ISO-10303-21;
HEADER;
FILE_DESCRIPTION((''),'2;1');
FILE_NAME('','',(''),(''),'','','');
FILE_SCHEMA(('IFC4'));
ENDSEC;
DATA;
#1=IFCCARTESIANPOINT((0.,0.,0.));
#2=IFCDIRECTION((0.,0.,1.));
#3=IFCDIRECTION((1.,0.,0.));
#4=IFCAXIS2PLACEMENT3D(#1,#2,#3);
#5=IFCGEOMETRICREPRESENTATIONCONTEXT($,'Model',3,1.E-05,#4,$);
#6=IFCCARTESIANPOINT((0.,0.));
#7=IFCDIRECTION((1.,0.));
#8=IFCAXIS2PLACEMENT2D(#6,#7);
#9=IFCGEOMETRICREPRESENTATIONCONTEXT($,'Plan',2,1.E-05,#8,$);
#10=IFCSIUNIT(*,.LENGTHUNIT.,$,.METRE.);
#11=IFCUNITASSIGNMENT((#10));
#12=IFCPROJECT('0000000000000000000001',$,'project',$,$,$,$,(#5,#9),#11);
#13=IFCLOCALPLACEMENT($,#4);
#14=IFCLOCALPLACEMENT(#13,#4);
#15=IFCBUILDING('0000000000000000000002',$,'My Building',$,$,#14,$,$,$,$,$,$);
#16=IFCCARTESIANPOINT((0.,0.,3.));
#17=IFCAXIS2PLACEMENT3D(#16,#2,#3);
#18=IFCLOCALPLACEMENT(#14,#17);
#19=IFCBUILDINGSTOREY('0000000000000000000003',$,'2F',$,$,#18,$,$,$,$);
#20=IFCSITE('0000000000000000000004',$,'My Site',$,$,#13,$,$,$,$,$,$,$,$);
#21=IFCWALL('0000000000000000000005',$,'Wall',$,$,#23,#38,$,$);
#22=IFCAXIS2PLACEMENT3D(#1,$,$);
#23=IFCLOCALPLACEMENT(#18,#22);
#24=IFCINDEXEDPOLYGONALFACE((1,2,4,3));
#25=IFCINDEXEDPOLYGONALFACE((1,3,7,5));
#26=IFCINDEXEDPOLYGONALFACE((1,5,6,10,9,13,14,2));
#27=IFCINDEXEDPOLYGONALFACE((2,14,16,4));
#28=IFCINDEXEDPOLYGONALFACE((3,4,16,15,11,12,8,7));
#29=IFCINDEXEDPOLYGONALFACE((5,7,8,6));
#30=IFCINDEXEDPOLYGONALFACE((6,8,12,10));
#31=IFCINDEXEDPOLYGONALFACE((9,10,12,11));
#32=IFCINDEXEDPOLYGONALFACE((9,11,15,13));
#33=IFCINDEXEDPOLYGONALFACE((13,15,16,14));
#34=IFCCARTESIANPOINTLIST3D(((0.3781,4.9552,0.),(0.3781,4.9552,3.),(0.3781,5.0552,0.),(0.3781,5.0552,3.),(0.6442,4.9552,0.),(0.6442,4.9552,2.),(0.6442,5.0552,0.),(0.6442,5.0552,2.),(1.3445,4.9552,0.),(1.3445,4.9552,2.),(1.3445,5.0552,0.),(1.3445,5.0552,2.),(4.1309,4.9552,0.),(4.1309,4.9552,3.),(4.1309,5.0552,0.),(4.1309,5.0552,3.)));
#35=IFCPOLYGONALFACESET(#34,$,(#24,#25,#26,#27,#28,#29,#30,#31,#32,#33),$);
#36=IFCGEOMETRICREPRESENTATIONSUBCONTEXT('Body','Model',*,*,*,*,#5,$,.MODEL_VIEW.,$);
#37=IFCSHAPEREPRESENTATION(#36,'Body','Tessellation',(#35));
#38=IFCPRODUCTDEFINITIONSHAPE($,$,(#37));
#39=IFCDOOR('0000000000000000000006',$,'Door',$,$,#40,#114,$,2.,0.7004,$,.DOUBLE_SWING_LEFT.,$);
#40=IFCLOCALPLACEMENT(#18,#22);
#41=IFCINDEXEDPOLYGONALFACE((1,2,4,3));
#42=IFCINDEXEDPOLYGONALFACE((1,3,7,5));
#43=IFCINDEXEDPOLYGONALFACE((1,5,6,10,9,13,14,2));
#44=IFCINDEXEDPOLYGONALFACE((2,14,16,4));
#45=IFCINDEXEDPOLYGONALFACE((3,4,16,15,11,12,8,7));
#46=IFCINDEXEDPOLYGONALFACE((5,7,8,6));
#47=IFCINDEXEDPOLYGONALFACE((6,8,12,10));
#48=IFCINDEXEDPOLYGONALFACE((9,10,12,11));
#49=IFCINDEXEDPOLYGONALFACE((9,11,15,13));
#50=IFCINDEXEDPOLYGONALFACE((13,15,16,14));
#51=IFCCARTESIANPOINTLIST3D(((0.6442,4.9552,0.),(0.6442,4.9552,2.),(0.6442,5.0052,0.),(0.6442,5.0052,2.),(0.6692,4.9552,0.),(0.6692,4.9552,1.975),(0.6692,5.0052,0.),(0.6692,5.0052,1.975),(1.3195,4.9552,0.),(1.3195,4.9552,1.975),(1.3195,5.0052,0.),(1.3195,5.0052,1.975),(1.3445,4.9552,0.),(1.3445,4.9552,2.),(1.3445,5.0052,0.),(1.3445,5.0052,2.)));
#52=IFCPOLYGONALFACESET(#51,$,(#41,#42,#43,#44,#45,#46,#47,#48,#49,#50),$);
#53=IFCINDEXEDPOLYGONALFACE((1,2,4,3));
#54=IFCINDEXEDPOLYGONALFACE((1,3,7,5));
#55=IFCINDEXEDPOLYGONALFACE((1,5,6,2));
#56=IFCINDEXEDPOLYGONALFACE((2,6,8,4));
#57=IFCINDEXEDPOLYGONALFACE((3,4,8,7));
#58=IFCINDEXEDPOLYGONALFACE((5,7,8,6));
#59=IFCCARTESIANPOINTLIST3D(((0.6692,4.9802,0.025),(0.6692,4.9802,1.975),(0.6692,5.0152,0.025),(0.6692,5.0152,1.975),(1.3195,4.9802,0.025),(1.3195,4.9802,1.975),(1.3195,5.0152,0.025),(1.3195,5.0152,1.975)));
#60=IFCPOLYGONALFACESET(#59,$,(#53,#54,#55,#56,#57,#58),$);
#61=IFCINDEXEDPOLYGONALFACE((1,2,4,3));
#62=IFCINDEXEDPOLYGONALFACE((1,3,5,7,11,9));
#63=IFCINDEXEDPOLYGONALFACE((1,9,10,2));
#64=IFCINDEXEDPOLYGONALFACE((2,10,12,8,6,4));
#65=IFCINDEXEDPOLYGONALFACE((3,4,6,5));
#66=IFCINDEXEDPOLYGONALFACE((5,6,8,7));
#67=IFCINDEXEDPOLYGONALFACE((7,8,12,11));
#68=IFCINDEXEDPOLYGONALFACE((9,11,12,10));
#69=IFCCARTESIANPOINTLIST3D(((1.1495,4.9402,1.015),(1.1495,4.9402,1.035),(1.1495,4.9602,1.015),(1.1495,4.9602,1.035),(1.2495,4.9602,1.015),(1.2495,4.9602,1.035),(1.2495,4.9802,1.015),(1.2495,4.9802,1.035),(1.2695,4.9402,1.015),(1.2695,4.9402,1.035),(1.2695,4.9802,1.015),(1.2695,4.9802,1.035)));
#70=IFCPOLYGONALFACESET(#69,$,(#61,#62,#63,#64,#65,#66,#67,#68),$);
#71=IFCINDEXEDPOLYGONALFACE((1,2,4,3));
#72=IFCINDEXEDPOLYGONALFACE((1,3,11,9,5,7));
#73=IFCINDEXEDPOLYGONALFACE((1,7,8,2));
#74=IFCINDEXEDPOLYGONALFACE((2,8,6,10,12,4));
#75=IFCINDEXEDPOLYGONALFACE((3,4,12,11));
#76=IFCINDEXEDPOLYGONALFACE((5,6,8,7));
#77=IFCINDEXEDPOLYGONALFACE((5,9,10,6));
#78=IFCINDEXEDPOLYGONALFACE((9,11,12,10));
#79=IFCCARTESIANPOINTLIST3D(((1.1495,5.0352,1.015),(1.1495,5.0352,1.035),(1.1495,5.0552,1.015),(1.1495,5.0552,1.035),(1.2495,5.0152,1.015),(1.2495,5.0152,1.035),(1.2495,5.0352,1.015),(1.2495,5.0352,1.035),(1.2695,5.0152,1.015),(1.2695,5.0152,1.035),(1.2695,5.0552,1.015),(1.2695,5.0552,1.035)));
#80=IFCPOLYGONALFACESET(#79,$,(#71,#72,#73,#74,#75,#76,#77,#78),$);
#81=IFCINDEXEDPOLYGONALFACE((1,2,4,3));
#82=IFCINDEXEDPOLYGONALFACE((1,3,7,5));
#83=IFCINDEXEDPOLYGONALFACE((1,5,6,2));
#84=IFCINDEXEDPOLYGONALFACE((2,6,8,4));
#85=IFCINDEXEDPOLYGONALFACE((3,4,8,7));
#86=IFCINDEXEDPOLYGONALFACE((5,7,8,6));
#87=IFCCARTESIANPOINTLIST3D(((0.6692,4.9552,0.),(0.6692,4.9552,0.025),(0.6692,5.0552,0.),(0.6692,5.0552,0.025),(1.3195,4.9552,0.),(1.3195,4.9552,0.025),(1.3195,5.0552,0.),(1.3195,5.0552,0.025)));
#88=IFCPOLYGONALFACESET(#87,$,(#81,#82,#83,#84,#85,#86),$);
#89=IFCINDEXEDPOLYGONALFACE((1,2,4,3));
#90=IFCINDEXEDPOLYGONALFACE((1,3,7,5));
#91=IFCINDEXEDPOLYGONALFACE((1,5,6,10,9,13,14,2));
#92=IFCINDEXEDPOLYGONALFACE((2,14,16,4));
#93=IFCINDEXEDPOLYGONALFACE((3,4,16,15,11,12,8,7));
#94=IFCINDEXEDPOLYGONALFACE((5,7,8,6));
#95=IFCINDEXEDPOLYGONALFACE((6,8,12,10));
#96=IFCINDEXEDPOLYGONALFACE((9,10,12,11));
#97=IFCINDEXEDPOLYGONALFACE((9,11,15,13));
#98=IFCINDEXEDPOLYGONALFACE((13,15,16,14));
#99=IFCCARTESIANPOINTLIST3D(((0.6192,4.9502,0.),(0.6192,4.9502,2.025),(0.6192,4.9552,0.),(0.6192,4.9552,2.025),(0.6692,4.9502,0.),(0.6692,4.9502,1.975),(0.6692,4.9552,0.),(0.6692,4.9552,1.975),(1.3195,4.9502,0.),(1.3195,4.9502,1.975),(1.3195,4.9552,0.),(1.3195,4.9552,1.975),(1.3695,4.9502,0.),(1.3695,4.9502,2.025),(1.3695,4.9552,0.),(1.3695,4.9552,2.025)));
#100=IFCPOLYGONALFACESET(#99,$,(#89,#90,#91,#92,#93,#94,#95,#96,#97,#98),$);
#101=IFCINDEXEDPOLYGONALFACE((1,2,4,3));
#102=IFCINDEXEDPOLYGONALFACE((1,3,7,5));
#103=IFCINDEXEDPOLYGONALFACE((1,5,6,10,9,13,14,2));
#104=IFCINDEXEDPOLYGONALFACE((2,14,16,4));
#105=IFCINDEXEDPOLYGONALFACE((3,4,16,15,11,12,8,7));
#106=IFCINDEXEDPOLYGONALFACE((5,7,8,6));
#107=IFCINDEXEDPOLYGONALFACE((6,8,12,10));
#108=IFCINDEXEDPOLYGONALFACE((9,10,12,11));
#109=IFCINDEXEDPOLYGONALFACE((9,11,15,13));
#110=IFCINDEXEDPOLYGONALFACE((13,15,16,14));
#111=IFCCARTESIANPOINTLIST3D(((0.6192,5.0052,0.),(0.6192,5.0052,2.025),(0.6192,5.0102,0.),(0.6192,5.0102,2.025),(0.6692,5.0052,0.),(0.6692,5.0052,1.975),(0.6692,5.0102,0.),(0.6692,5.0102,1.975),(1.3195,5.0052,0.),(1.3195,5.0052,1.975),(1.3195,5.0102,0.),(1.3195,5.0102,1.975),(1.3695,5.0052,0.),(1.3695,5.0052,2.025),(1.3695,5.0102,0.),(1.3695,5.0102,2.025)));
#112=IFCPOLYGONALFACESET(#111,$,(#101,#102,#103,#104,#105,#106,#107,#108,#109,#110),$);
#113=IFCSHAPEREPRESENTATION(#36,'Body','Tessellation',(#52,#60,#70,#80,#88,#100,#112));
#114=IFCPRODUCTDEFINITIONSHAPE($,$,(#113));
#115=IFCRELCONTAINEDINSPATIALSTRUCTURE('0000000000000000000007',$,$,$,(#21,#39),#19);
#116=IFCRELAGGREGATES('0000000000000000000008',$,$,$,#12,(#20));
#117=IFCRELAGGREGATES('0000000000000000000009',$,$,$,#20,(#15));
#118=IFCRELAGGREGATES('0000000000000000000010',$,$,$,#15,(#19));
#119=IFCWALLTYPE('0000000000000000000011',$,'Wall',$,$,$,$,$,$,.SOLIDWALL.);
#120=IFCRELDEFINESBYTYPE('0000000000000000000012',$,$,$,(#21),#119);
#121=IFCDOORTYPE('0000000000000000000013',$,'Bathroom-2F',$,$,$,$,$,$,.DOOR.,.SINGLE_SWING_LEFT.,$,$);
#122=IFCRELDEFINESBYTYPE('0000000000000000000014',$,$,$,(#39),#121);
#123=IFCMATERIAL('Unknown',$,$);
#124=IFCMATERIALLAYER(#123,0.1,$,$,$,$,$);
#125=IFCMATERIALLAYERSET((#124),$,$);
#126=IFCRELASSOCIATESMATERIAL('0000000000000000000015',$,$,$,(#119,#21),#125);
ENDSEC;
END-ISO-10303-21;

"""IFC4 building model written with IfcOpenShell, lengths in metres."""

from ifc_helpers import new_model, entity, si_unit, frame, origin_with_axes, origin_2d_with_axis, place, context, subcontext, project, spatial, line, indexed_curve, outline, extrude, shape, source, transform, mapped, material, layer, layer_set, layer_usage, type_object, type_shapes, element, fill, save


model = new_model("IFC4")

# Units and contexts
model_context = context("Model", 3, precision=1e-05, world=origin_with_axes())
plan_context = context("Plan", 2, precision=1e-05, world=origin_2d_with_axis())
body_context_1 = subcontext(model_context, "Body", "Model", "MODEL_VIEW")
body_context_2 = subcontext(plan_context, "Body", "Plan", "PLAN_VIEW")
ifc_project = project(units=[si_unit("LENGTHUNIT", "METRE")], contexts=[model_context, plan_context])

# Site, building, storey
site_placement = place(None, origin_with_axes())
site = spatial("IfcSite", under=ifc_project, at=site_placement, Name="My Site")
building_placement = place(site_placement, origin_with_axes())
building = spatial("IfcBuilding", under=site, at=building_placement, Name="My Building")
storey_placement = place(building_placement, frame((0.0, 0.0, 3.0), z_axis=(0.0, 0.0, 1.0), x_axis=(1.0, 0.0, 0.0)))
storey = spatial("IfcBuildingStorey", under=building, at=storey_placement, Name="2F")

# Shared definitions
ifc_material = material(Name="Unknown")

# Shared definitions
ifc_layer = layer(ifc_material, 0.1)
ifc_layer_set = layer_set([ifc_layer])
wall_type = type_object("IfcWallType", Name="Wall", PredefinedType="SOLIDWALL", material=ifc_layer_set)

# Wall, opening, door
ifc_layer_usage_1 = layer_usage(ifc_layer_set, "AXIS2", "POSITIVE", 0.0)
wall_1_placement = place(storey_placement, frame((4.2309, 5.0552, 0.0), z_axis=(0.0, 0.0, 1.0), x_axis=(-1.0, 0.0, 0.0)))
wall_1 = element("IfcWall", 1, at=wall_1_placement, inside=storey, type_object=wall_type, material=ifc_layer_usage_1, Name="Wall", context=body_context_1, shape_type="SweptSolid", body=[
    extrude(outline(indexed_curve([(0.1, 0.0), (0.1, 0.1), (3.8528, 0.1), (3.8528, 0.0)], segments=[line(1, 2, 3, 4, 1)])), origin_with_axes(), (0.0, 0.0, 1.0), 3.0),
])
shared_shape_1 = source(origin_with_axes(), body_context_1, "Body", "SweptSolid", [
    extrude(outline(indexed_curve([(0.0, 0.0), (0.7004, 0.0), (0.7004, 2.0), (0.0, 2.0)], segments=[line(1, 2, 3, 4, 1)])), frame((0.0, -0.6, 0.0), z_axis=(0.0, -1.0, 0.0), x_axis=(1.0, 0.0, 0.0)), (0.0, 0.0, -1.0), 1.2),
])
opening_1_placement = place(wall_1_placement, frame((3.5867, 0.1, 0.0), z_axis=(0.0, 0.0, 1.0), x_axis=(-1.0, 0.0, 0.0)))
opening_1 = element("IfcOpeningElement", 2, at=opening_1_placement, cuts=wall_1, PredefinedType="OPENING", context=body_context_1, shape_type="MappedRepresentation", body=[
    mapped(shared_shape_1, transform((0.0, 0.0, 0.0), x_axis=(1.0, 0.0, 0.0), y_axis=(0.0, 1.0, 0.0), z_axis=(0.0, 0.0, 1.0), scale=1.0)),
])
door_type_1 = type_object("IfcDoorType", Name="Bathroom-2F", OperationType="SINGLE_SWING_LEFT", PredefinedType="DOOR")
shared_shape_2 = source(origin_with_axes(), body_context_1, "Body", "SweptSolid", [
    extrude(outline(indexed_curve([(0.0, 0.0), (0.0, 2.0), (0.7004, 2.0), (0.7004, 0.0), (0.6754, 0.0), (0.6754, 1.975), (0.025, 1.975), (0.025, 0.0)], segments=[line(1, 2, 3, 4, 5, 6, 7, 8, 1)])), frame((0.0, 0.0, 0.0), z_axis=(0.0, -1.0, 0.0), x_axis=(1.0, 0.0, 0.0)), (0.0, 0.0, -1.0), 0.05),
    extrude(outline(indexed_curve([(0.0, 0.0), (0.6504, 0.0), (0.6504, 0.035), (0.0, 0.035)], segments=[line(1, 2, 3, 4, 1)])), frame((0.025, 0.025, 0.025), z_axis=(0.0, 0.0, 1.0), x_axis=(1.0, 0.0, 0.0)), (0.0, 0.0, 1.0), 1.95),
    extrude(outline(indexed_curve([(0.0, 0.0), (0.0, -0.04), (-0.12, -0.04), (-0.12, -0.02), (-0.02, -0.02), (-0.02, 0.0)], segments=[line(1, 2, 3, 4, 5, 6, 1)])), frame((0.6254, 0.025, 1.015), z_axis=(0.0, 0.0, 1.0), x_axis=(1.0, 0.0, 0.0)), (0.0, 0.0, 1.0), 0.02),
    extrude(outline(indexed_curve([(0.0, 0.0), (0.0, 0.04), (-0.12, 0.04), (-0.12, 0.02), (-0.02, 0.02), (-0.02, 0.0)], segments=[line(1, 2, 3, 4, 5, 6, 1)])), frame((0.6254, 0.06, 1.015), z_axis=(0.0, 0.0, 1.0), x_axis=(1.0, 0.0, 0.0)), (0.0, 0.0, 1.0), 0.02),
    extrude(outline(indexed_curve([(0.0, 0.0), (0.6504, 0.0), (0.6504, 0.1), (0.0, 0.1)], segments=[line(1, 2, 3, 4, 1)])), frame((0.025, 0.0, 0.0), z_axis=(0.0, 0.0, 1.0), x_axis=(1.0, 0.0, 0.0)), (0.0, 0.0, 1.0), 0.025),
    extrude(outline(indexed_curve([(0.0, 0.0), (0.0, 2.025), (0.7504, 2.025), (0.7504, 0.0), (0.7004, 0.0), (0.7004, 1.975), (0.05, 1.975), (0.05, 0.0)], segments=[line(1, 2, 3, 4, 5, 6, 7, 8, 1)])), frame((-0.025, -0.005, 0.0), z_axis=(0.0, -1.0, 0.0), x_axis=(1.0, 0.0, 0.0)), (0.0, 0.0, -1.0), 0.005),
    extrude(outline(indexed_curve([(0.0, 0.0), (0.0, 2.025), (0.7504, 2.025), (0.7504, 0.0), (0.7004, 0.0), (0.7004, 1.975), (0.05, 1.975), (0.05, 0.0)], segments=[line(1, 2, 3, 4, 5, 6, 7, 8, 1)])), frame((-0.025, 0.05, 0.0), z_axis=(0.0, -1.0, 0.0), x_axis=(1.0, 0.0, 0.0)), (0.0, 0.0, -1.0), 0.005),
])
shared_shape_3 = source(origin_with_axes(), body_context_2, "Body", "Curve2D", [
    entity("IfcIndexedPolyCurve", entity("IfcCartesianPointList2D", [[0.0, 0.0], [0.025, 0.0], [0.025, 0.05], [0.0, 0.05]]), [entity("IfcLineIndex", [1, 2, 3, 4, 1])]),
    entity("IfcIndexedPolyCurve", entity("IfcCartesianPointList2D", [[0.7004, 0.0], [0.6754, 0.0], [0.6754, 0.05], [0.7004, 0.05]]), [entity("IfcLineIndex", [1, 2, 3, 4, 1])]),
    entity("IfcIndexedPolyCurve", entity("IfcCartesianPointList2D", [[0.025, 0.05], [0.025, -0.6004], [0.06, -0.6004]])),
    entity("IfcTrimmedCurve", entity("IfcEllipse", entity("IfcAxis2Placement2D", entity("IfcCartesianPoint", [0.06, 0.05]), entity("IfcDirection", [1.0, 0.0])), 0.6154, 0.6504), [entity("IfcCartesianPoint", [0.06, -0.6004])], [entity("IfcCartesianPoint", [0.06, 0.7004])], True, "CARTESIAN"),
    entity("IfcIndexedPolyCurve", entity("IfcCartesianPointList2D", [[0.025, 0.05], [0.06, 0.05], [0.06, 0.7004], [0.025, 0.7004]]), [entity("IfcLineIndex", [1, 2, 3, 4, 1])]),
])
type_shapes(door_type_1, [shared_shape_2, shared_shape_3])
door_1_placement = place(opening_1_placement, origin_with_axes())
door_1 = element("IfcDoor", 3, at=door_1_placement, inside=storey, type_object=door_type_1, Name="Door", OperationType="DOUBLE_SWING_LEFT", OverallHeight=2.0, OverallWidth=0.7004, shapes=[
    shape(body_context_1, "Body", "MappedRepresentation", [mapped(shared_shape_2, transform((0.0, 0.0, 0.0), x_axis=(1.0, 0.0, 0.0), y_axis=(0.0, 1.0, 0.0), z_axis=(0.0, 0.0, 1.0), scale=1.0))]),
    shape(body_context_2, "Body", "MappedRepresentation", [mapped(shared_shape_3, transform((0.0, 0.0, 0.0), x_axis=(1.0, 0.0, 0.0), y_axis=(0.0, 1.0, 0.0), z_axis=(0.0, 0.0, 1.0), scale=1.0))]),
])
fill(opening_1, door_1)

save(model, "model.ifc")
